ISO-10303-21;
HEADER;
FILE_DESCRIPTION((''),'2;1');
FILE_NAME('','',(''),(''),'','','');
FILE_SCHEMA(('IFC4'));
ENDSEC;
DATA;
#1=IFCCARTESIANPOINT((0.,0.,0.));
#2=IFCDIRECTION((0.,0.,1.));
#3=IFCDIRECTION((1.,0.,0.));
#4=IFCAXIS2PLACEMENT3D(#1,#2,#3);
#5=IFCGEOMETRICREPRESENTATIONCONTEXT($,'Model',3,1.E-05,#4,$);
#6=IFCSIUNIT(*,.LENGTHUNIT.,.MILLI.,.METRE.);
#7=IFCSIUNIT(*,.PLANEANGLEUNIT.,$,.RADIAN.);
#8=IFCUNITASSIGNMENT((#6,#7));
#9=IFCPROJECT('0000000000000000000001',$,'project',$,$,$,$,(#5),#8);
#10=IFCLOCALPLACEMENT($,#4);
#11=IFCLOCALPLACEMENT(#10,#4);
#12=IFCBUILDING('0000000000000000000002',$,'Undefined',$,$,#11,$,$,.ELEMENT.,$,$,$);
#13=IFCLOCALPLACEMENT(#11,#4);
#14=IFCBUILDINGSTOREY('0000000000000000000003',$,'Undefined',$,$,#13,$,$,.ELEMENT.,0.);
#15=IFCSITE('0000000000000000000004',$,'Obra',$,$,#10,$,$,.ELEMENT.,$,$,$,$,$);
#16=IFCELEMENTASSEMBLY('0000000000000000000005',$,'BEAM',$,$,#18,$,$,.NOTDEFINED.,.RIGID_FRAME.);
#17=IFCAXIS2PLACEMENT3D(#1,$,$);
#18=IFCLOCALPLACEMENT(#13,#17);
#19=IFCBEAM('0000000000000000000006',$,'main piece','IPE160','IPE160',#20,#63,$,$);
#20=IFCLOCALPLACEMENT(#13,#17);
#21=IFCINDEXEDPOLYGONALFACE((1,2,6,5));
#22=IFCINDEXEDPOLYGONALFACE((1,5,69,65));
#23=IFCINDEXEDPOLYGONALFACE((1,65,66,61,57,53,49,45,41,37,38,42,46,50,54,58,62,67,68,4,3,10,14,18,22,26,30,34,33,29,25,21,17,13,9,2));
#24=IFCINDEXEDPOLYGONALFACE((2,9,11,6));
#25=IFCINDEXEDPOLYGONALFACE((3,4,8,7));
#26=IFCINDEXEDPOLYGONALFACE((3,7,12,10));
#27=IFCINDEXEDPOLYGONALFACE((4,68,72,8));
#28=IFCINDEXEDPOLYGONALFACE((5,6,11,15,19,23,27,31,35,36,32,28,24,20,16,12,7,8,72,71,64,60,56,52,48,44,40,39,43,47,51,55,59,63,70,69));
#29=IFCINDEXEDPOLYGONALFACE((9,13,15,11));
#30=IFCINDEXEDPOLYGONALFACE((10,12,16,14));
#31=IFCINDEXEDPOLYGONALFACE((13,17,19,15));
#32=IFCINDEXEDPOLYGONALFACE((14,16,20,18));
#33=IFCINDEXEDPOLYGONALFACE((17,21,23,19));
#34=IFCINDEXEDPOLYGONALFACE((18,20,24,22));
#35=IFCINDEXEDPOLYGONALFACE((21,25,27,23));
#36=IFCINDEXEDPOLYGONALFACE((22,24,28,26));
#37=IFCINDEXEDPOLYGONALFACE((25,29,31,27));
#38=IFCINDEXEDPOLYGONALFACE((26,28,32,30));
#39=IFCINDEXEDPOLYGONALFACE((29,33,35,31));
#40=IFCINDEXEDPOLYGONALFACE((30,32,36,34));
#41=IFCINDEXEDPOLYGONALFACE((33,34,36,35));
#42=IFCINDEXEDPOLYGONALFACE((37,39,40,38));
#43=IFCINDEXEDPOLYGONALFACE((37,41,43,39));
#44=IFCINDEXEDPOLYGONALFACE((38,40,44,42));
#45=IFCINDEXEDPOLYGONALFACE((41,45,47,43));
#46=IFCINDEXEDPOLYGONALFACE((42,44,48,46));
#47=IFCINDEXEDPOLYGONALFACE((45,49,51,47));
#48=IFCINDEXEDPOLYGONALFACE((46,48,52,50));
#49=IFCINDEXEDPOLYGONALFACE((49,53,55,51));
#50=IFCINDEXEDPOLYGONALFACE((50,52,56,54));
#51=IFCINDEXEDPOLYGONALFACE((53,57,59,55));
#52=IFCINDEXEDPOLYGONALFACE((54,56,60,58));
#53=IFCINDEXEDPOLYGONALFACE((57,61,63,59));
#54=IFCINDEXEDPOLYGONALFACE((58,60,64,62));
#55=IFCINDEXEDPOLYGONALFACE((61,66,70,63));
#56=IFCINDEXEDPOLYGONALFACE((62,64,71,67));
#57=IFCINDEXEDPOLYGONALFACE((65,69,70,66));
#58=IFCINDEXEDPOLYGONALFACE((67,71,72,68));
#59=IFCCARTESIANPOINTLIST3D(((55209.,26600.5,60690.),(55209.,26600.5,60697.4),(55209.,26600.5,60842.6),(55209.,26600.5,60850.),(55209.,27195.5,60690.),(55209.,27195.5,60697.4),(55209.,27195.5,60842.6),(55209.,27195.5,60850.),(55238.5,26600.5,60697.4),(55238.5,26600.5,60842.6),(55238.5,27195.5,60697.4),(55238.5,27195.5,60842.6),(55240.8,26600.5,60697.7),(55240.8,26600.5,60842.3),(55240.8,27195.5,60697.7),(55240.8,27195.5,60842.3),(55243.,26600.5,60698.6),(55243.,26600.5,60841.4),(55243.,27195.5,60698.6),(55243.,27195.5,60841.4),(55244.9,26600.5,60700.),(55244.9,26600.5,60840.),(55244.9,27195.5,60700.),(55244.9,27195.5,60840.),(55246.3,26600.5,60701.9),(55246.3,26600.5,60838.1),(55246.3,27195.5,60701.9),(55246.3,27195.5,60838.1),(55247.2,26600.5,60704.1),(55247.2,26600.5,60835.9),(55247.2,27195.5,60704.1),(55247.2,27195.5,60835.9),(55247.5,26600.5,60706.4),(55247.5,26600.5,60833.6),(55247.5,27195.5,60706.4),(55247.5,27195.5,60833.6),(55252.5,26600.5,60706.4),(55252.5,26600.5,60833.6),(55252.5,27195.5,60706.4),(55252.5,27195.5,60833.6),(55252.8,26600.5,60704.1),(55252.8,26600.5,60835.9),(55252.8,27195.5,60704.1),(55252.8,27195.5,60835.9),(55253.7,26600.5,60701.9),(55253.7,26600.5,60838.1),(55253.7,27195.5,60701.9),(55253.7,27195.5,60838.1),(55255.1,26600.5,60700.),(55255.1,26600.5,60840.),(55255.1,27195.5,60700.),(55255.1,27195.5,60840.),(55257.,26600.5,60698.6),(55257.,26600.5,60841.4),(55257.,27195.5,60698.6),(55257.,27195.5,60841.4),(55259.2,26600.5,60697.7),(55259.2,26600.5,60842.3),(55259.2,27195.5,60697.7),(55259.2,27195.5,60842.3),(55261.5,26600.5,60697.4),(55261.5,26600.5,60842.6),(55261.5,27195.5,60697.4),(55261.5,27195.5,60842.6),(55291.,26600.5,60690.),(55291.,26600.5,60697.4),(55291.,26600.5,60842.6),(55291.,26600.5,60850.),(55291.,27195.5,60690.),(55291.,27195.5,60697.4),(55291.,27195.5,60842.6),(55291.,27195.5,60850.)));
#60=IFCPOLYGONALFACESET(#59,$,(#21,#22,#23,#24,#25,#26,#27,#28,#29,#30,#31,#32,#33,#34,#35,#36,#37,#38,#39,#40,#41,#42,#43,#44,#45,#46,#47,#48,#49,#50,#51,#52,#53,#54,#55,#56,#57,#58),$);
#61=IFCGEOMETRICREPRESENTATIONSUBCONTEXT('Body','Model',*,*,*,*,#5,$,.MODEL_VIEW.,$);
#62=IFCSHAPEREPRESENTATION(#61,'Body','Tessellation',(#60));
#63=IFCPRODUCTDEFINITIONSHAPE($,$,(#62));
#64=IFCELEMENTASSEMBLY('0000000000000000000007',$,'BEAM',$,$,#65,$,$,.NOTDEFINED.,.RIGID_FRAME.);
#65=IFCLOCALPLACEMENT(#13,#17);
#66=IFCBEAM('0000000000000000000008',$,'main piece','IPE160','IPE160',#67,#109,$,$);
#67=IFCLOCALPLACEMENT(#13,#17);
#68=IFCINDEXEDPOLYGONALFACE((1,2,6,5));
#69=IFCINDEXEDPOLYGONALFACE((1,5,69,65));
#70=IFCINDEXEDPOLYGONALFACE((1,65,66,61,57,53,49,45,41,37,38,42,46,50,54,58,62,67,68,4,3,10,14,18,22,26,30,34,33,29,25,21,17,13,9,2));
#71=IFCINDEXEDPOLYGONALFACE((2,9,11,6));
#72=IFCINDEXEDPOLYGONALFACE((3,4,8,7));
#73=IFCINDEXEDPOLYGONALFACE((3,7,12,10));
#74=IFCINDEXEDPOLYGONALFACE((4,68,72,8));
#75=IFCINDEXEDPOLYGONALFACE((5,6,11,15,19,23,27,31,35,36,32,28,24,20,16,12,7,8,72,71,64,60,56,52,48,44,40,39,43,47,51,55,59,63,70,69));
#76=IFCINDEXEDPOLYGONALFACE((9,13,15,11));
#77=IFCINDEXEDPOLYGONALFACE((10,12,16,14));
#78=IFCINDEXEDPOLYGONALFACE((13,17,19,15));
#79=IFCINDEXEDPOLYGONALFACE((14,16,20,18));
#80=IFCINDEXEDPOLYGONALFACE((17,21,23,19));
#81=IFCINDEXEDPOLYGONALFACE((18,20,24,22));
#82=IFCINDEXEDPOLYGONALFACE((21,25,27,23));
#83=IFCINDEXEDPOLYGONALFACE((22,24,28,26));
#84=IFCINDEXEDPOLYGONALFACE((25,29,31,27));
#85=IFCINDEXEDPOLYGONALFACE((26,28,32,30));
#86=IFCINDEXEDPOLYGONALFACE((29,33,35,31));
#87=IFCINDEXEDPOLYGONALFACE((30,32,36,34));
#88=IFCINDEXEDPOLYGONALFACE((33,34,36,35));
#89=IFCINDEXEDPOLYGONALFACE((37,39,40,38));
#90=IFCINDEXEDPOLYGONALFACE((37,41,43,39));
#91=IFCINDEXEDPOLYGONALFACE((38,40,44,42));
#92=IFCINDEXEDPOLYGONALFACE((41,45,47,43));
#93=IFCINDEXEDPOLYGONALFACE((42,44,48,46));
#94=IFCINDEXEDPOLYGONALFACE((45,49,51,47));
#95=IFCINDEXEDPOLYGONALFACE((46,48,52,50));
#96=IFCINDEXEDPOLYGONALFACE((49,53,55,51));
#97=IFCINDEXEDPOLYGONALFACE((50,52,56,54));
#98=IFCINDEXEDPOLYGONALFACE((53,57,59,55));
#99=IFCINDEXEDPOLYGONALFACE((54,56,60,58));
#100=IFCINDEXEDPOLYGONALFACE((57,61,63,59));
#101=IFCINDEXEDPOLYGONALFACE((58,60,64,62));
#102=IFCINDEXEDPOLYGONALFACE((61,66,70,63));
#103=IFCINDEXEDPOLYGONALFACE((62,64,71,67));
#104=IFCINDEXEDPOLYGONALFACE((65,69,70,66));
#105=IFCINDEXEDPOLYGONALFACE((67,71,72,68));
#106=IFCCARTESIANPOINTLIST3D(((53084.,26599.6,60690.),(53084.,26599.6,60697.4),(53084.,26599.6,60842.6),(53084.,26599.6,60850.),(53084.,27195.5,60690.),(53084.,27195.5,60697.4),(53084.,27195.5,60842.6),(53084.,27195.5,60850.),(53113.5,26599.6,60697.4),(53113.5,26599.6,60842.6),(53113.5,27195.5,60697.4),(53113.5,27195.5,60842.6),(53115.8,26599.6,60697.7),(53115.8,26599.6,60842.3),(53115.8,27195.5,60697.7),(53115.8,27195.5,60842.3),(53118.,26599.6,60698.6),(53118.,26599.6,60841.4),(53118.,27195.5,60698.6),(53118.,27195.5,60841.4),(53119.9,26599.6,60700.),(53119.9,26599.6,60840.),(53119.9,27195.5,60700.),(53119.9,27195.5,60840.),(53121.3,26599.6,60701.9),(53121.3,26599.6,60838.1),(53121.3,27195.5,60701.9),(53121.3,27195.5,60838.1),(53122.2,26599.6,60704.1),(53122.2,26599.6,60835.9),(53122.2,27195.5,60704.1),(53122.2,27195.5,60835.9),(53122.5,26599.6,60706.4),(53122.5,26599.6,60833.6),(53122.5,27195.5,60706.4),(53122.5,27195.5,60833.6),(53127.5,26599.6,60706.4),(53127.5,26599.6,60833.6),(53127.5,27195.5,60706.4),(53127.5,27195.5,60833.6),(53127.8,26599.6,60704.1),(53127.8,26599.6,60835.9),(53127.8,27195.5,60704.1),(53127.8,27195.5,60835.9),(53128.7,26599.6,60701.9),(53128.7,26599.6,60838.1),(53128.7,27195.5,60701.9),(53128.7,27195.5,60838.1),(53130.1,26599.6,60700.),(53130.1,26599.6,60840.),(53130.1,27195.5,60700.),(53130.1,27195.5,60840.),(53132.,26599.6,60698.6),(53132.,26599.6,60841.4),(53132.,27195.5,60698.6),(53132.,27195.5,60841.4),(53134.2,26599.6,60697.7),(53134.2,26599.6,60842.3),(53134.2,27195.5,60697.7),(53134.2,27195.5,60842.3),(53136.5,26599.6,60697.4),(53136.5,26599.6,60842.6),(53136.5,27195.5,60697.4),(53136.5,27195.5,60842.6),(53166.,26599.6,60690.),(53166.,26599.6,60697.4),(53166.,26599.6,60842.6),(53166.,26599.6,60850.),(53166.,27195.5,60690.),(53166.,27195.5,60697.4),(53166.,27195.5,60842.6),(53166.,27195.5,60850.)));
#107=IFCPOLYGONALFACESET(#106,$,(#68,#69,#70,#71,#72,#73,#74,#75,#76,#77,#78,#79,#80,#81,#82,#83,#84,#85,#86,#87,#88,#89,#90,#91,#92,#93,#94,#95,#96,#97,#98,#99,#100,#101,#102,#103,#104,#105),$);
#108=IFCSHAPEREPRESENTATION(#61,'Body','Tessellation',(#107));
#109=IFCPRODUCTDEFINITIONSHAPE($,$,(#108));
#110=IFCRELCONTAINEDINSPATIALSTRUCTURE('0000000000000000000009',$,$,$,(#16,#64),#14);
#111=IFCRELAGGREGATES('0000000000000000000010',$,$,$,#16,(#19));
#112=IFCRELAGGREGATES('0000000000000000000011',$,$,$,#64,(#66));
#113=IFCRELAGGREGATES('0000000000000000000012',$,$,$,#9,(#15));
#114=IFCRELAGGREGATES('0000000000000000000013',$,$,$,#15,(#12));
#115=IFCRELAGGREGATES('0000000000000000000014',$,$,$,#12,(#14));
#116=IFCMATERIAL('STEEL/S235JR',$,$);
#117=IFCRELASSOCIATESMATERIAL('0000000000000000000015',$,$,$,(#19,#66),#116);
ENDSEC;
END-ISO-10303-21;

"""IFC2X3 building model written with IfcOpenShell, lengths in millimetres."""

from ifc_helpers import new_model, si_unit, frame, origin_with_axes, origin_2d_with_axis, place, context, subcontext, project, spatial, i_section, extrude, material, element, aggregate, save


model = new_model("IFC2X3")

# Units and contexts
model_context = context("Model", 3, precision=1e-05, world=origin_with_axes())
body_context = subcontext(model_context, "Body", "Model", "MODEL_VIEW")
ifc_project = project(units=[si_unit("LENGTHUNIT", "METRE", prefix="MILLI"), si_unit("PLANEANGLEUNIT", "RADIAN")], contexts=[model_context])

# Site, building, storey
site_placement = place(None, origin_with_axes())
site = spatial("IfcSite", under=ifc_project, at=site_placement, Name="Obra", CompositionType="ELEMENT")
building_placement = place(site_placement, origin_with_axes())
building = spatial("IfcBuilding", under=site, at=building_placement, Name="Undefined", CompositionType="ELEMENT")
storey_placement = place(building_placement, origin_with_axes())
storey = spatial("IfcBuildingStorey", under=building, at=storey_placement, Name="Undefined", CompositionType="ELEMENT", Elevation=0.0)

# Element assemblies, beams
ifc_material_1 = material(Name="STEEL/S235JR")
assembly_1_placement = place(storey_placement, origin_with_axes())
assembly_1 = element("IfcElementAssembly", 1, at=assembly_1_placement, inside=storey, Name="BEAM", AssemblyPlace="NOTDEFINED", PredefinedType="RIGID_FRAME")
beam_1_placement = place(assembly_1_placement, frame((55250.0, 26600.5, 60770.0), z_axis=(0.0, 0.0, 1.0), x_axis=(0.0, 1.0, 0.0)))
beam_1 = element("IfcBeam", 2, at=beam_1_placement, material=ifc_material_1, Name="main piece", Description="IPE160", ObjectType="IPE160", context=body_context, shape_type="SweptSolid", body=[
    extrude(i_section(OverallWidth=82.0, OverallDepth=160.0, WebThickness=5.0, FlangeThickness=7.4, FilletRadius=9.0, at=origin_2d_with_axis()), frame((595.0, 0.0, 0.0), z_axis=(-1.0, 0.0, 0.0), x_axis=(0.0, -1.0, 0.0)), (0.0, 0.0, 1.0), 595.0),
])
aggregate(assembly_1, [beam_1])
assembly_2_placement = place(storey_placement, origin_with_axes())
assembly_2 = element("IfcElementAssembly", 3, at=assembly_2_placement, inside=storey, Name="BEAM", AssemblyPlace="NOTDEFINED", PredefinedType="RIGID_FRAME")
beam_2_placement = place(assembly_2_placement, frame((53125.0, 26599.6, 60770.0), z_axis=(0.0, 0.0, 1.0), x_axis=(0.0, 1.0, 0.0)))
beam_2 = element("IfcBeam", 4, at=beam_2_placement, material=ifc_material_1, Name="main piece", Description="IPE160", ObjectType="IPE160", context=body_context, shape_type="SweptSolid", body=[
    extrude(i_section(OverallWidth=82.0, OverallDepth=160.0, WebThickness=5.0, FlangeThickness=7.4, FilletRadius=9.0, at=origin_2d_with_axis()), frame((595.9, 0.0, 0.0), z_axis=(-1.0, 0.0, 0.0), x_axis=(0.0, -1.0, 0.0)), (0.0, 0.0, 1.0), 595.9),
])
aggregate(assembly_2, [beam_2])

save(model, "model.ifc")
